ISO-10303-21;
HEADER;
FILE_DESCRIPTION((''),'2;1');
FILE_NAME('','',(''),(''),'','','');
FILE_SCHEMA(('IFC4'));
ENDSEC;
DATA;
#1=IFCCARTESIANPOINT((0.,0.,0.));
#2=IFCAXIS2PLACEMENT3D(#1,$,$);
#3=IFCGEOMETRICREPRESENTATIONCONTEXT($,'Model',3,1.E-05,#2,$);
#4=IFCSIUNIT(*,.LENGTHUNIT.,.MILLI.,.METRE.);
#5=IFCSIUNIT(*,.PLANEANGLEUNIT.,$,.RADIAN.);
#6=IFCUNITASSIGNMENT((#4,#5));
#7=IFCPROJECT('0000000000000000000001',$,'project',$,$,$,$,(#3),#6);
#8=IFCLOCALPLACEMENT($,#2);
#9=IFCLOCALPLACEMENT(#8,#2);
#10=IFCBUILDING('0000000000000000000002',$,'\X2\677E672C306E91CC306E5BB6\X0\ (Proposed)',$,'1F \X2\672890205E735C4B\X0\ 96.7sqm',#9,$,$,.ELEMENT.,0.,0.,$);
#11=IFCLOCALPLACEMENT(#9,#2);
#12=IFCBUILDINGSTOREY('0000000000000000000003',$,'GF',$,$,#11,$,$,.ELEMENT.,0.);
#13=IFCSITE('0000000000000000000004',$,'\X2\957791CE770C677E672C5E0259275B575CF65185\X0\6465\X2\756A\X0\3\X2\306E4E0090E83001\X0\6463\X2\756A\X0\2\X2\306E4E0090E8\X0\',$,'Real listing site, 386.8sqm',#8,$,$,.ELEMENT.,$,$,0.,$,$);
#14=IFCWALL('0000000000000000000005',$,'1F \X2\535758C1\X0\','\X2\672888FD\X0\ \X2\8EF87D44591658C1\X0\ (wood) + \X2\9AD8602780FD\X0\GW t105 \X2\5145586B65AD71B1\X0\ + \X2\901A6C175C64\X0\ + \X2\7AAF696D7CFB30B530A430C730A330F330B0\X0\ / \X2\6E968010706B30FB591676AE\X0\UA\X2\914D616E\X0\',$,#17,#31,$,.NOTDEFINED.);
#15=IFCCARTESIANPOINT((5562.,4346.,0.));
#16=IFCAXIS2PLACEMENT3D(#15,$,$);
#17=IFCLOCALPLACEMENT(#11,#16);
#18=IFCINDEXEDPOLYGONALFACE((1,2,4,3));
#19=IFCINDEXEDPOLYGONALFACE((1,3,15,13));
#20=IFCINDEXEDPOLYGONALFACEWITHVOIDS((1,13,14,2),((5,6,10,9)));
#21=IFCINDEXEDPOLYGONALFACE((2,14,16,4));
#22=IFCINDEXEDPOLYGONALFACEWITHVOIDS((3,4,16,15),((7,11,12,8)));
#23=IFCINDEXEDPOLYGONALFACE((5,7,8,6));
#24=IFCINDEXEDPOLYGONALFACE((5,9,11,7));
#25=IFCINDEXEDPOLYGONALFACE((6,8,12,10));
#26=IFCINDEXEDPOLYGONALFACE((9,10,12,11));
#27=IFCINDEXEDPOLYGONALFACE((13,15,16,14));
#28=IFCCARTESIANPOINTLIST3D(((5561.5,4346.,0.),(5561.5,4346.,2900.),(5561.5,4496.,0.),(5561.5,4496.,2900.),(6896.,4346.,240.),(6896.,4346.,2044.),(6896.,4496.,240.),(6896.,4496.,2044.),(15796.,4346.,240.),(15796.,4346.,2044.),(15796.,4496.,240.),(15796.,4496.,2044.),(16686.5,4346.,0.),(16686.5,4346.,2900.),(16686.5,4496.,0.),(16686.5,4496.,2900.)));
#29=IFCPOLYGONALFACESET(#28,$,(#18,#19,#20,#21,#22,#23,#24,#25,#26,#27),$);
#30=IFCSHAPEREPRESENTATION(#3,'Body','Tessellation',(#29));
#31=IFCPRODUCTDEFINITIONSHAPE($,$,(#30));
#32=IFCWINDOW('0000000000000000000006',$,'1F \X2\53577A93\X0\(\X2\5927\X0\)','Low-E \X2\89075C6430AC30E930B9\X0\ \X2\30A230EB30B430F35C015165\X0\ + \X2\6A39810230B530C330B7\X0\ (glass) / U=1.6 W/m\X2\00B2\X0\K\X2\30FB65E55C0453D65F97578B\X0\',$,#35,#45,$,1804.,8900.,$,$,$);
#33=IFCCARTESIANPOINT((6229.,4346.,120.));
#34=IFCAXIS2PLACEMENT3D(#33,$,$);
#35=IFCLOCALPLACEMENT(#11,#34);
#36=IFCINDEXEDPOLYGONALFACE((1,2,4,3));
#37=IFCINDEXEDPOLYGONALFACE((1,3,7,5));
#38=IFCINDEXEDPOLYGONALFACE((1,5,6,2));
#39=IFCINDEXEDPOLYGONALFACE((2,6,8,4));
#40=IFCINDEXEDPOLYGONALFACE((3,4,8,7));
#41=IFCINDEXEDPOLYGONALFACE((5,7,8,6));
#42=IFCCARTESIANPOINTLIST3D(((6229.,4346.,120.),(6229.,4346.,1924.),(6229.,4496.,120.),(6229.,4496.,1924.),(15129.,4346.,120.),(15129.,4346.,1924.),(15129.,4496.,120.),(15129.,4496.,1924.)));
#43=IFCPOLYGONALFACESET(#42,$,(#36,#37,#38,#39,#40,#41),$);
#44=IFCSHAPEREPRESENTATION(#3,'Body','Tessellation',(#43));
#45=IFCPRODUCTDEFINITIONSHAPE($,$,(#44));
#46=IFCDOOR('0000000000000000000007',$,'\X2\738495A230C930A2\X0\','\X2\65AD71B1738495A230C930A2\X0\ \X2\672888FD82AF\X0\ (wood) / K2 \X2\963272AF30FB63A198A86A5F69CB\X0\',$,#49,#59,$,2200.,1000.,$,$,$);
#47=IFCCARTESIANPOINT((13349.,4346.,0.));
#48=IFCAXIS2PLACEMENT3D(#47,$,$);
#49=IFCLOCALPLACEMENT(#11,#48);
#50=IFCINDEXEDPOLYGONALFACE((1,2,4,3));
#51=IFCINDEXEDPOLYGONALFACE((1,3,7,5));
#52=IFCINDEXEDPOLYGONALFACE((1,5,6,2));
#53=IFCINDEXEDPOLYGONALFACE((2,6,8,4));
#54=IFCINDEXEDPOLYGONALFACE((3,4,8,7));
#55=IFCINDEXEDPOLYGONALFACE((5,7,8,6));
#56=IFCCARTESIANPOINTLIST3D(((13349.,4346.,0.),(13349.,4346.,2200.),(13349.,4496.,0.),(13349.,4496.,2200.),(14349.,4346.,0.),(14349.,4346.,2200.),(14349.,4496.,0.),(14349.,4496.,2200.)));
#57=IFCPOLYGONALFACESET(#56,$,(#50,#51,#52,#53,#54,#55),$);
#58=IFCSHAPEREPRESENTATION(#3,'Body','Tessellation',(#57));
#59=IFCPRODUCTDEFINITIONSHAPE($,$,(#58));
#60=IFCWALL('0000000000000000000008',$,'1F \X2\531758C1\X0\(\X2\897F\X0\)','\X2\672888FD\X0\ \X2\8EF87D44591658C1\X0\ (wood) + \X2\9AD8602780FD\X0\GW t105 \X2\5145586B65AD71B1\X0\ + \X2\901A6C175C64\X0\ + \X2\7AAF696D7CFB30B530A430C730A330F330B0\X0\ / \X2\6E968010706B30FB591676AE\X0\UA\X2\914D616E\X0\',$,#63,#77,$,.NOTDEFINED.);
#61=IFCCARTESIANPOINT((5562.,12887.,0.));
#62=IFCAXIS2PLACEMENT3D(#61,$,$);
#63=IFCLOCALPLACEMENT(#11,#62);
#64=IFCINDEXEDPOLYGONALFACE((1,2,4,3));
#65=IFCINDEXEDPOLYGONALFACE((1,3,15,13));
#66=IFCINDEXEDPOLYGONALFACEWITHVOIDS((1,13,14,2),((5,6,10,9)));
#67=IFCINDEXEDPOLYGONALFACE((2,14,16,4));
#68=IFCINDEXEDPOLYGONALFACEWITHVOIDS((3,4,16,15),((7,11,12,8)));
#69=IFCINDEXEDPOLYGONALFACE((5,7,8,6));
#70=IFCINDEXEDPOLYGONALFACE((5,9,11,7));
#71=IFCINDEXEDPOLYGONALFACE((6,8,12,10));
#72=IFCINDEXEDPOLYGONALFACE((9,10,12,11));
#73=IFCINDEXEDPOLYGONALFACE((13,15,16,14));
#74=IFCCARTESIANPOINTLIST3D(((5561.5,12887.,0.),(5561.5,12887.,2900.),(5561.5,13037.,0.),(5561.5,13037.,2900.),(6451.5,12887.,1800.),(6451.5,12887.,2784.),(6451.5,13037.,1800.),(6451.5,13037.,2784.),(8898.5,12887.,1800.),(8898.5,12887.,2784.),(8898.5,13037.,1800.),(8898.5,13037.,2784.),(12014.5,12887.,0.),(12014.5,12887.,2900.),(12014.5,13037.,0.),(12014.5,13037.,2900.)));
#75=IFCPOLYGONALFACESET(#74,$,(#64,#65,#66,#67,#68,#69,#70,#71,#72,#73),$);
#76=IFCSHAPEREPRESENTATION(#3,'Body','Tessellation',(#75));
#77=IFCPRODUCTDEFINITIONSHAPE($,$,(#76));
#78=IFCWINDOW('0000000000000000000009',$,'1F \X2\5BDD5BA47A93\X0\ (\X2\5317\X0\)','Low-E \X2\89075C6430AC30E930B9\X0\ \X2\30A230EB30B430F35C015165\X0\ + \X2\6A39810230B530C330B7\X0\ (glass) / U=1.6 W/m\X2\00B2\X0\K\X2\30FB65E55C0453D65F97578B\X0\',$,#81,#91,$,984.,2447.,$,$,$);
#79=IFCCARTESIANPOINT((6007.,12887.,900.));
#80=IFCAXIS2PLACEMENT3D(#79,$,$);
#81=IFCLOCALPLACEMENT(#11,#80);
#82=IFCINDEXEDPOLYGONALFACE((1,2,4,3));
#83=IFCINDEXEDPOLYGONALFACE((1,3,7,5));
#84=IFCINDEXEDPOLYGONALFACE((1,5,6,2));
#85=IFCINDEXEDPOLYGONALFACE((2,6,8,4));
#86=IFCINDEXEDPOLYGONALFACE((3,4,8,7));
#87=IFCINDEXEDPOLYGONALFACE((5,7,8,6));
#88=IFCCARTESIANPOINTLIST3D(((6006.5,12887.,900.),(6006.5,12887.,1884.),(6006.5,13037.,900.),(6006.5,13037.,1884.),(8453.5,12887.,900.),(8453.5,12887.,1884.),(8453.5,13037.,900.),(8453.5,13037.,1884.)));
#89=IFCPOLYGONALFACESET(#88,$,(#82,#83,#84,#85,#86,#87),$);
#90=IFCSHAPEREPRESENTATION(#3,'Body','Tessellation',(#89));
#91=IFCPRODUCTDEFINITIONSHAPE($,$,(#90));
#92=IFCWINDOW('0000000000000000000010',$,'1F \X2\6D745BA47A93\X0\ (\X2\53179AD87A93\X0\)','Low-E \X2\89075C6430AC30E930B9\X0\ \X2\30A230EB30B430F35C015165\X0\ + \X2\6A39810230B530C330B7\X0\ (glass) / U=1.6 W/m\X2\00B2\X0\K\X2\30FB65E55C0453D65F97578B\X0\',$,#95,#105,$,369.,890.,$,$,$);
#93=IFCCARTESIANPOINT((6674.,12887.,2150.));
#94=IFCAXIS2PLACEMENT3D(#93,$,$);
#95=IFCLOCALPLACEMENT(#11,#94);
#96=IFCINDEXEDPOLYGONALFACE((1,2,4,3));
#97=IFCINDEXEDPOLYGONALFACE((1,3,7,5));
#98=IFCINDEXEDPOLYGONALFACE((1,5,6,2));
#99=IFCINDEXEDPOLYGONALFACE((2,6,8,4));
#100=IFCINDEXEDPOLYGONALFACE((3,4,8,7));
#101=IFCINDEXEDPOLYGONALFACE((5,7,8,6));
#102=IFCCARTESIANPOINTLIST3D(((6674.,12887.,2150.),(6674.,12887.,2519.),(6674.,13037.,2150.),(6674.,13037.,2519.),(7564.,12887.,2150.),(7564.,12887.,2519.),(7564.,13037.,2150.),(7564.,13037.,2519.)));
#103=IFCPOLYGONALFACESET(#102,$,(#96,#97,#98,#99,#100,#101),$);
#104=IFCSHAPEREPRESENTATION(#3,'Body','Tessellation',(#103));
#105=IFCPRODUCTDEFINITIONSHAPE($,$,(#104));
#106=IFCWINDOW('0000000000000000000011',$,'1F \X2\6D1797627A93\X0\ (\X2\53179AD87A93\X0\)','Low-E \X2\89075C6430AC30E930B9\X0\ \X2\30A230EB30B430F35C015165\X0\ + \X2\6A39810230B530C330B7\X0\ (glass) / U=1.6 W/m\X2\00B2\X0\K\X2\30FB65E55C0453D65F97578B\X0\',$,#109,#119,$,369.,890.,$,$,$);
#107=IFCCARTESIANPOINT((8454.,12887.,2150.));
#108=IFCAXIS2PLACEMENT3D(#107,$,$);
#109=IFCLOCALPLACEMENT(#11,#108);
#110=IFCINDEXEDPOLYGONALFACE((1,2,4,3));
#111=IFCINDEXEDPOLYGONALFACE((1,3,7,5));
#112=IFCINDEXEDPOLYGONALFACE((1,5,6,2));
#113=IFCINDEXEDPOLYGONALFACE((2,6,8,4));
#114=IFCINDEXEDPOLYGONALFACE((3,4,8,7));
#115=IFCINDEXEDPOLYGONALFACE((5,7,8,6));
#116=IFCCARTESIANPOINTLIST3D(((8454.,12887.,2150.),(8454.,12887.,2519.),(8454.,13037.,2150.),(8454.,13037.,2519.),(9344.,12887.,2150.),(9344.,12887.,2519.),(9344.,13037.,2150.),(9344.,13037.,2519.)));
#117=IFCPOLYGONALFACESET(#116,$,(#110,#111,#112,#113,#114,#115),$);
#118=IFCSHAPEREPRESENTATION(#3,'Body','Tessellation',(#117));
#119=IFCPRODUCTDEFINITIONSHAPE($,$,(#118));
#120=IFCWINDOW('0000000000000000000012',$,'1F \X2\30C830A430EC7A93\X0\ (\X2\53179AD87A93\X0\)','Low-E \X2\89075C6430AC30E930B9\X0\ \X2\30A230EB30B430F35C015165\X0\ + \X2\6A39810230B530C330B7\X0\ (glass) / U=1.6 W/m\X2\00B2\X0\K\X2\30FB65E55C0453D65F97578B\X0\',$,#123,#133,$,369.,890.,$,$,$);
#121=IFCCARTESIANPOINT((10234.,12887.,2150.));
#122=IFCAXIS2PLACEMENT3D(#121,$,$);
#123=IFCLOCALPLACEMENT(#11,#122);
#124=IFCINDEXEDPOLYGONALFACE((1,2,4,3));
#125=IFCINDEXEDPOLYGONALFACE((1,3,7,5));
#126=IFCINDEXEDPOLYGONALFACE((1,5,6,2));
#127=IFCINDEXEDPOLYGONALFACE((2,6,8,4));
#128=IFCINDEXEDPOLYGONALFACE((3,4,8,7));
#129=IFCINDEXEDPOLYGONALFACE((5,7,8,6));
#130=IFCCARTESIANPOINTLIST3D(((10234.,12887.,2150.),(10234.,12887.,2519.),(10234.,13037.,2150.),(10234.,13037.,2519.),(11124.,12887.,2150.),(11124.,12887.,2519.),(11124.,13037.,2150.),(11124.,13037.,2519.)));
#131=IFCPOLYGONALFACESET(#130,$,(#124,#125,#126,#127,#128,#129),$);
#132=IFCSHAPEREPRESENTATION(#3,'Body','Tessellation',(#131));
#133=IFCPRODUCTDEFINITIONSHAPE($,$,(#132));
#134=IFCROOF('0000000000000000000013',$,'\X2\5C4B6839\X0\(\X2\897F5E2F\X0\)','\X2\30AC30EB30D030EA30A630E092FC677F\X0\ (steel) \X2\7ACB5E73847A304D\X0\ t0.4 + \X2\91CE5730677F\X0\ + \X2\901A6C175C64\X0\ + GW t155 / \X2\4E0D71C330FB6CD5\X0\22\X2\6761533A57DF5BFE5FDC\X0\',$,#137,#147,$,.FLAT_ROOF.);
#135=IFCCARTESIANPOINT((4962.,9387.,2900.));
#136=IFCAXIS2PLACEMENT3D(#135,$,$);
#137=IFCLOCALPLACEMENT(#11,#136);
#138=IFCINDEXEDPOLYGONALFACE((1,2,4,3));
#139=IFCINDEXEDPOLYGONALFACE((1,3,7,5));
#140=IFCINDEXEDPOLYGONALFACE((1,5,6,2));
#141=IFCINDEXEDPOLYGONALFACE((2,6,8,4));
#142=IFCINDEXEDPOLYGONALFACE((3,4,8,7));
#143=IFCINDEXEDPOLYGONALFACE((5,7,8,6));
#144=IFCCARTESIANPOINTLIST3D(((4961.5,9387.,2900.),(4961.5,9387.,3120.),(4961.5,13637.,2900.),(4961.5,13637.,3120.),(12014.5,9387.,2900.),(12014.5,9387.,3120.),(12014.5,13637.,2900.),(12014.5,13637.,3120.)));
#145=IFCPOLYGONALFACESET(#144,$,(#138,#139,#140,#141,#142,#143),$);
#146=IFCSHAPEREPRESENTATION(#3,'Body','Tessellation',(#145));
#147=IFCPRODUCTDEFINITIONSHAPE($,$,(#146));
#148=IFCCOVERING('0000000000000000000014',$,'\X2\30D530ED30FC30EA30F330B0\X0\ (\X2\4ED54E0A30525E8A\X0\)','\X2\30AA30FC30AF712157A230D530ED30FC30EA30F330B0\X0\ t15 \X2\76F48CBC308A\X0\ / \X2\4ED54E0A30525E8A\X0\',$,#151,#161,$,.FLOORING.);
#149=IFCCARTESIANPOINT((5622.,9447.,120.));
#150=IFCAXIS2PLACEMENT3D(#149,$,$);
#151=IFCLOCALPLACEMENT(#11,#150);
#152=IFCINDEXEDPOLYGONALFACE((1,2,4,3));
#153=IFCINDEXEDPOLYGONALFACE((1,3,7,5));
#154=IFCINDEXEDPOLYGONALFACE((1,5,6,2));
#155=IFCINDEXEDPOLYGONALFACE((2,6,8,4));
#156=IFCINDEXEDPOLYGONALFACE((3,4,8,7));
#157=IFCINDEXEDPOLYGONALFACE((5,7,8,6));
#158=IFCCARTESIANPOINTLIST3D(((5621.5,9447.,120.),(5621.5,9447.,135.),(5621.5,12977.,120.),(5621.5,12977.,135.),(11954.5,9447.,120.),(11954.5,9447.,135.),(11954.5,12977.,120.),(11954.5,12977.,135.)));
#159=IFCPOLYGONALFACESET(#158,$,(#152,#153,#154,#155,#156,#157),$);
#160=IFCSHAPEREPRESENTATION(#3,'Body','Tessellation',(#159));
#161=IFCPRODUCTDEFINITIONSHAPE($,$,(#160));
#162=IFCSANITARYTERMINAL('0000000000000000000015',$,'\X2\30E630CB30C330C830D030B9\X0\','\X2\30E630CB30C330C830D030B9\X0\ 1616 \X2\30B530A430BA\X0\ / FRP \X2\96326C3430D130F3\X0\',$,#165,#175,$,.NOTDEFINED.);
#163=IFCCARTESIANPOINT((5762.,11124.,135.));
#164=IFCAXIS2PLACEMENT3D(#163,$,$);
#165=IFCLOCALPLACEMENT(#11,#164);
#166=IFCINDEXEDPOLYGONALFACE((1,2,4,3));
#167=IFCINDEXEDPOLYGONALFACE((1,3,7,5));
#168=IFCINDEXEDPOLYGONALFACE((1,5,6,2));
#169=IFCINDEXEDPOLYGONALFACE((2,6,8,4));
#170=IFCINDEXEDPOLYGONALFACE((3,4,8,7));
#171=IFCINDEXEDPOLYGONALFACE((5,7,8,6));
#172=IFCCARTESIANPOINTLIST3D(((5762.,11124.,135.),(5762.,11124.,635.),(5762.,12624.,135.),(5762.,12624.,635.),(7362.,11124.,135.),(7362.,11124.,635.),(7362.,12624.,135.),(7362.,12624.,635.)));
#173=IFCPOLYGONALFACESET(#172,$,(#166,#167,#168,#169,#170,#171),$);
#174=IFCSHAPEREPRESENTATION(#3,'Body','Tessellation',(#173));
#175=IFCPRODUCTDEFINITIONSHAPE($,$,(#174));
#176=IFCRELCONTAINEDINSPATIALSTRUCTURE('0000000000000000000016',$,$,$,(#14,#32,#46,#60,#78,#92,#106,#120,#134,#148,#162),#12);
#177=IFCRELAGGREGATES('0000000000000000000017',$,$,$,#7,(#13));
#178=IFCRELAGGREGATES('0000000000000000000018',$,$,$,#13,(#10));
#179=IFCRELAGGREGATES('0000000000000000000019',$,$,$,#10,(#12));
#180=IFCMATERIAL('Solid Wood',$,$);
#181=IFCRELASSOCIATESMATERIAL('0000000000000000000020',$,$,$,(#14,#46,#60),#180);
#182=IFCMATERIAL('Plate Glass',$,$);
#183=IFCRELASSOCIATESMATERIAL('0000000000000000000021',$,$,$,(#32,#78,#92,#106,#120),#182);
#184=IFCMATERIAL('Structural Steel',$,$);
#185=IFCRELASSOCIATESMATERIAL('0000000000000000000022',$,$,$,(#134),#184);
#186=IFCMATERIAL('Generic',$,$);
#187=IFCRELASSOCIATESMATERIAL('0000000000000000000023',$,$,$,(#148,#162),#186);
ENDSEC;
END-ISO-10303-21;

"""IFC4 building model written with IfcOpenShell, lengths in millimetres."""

from ifc_helpers import new_model, si_unit, frame, frame_2d, origin, place, context, project, spatial, rectangle, extrude, material, element, fill, save


model = new_model("IFC4")

# Units and contexts
model_context = context("Model", 3, precision=1e-05, world=origin())
ifc_project = project(units=[si_unit("LENGTHUNIT", "METRE", prefix="MILLI"), si_unit("PLANEANGLEUNIT", "RADIAN")], contexts=[model_context])

# Site, building, storey
site_placement = place(None, origin())
site = spatial("IfcSite", under=ifc_project, at=site_placement, Name="長野県松本市大字島内6465番3の一部、6463番2の一部", ObjectType="Real listing site, 386.8sqm", CompositionType="ELEMENT", RefElevation=0.0)
building_placement = place(site_placement, origin())
building = spatial("IfcBuilding", under=site, at=building_placement, Name="松本の里の家 (Proposed)", ObjectType="1F 木造平屋 96.7sqm", CompositionType="ELEMENT", ElevationOfRefHeight=0.0, ElevationOfTerrain=0.0)
storey_placement = place(building_placement, origin())
storey = spatial("IfcBuildingStorey", under=building, at=storey_placement, Name="GF", CompositionType="ELEMENT", Elevation=0.0)

# Shared definitions
ifc_material_1 = material(Name="Solid Wood")

# Wall, openings, window, door
wall_1_placement = place(storey_placement, frame((5562.0, 4346.0, 0.0)))
wall_1 = element("IfcWall", 1, at=wall_1_placement, inside=storey, material=ifc_material_1, Name="1F 南壁", Description="木製 軸組外壁 (wood) + 高性能GW t105 充填断熱 + 通気層 + 窯業系サイディング / 準耐火・外皮UA配慮", PredefinedType="NOTDEFINED", context=model_context, shape_type="SweptSolid", body=[
    extrude(rectangle(XDim=11125.0, YDim=150.0, at=frame_2d((5562.0, 75.0))), frame((5562.0, 4346.0, 0.0)), (0.0, 0.0, 1.0), 2900.0),
])
opening_1_placement = place(storey_placement, frame((6229.0, 4346.0, 120.0)))
opening_1 = element("IfcOpeningElement", 2, at=opening_1_placement, cuts=wall_1, PredefinedType="NOTDEFINED", context=model_context, shape_type="SweptSolid", body=[
    extrude(rectangle(XDim=8900.0, YDim=150.0, at=frame_2d((4450.0, 75.0))), frame((6229.0, 4346.0, 120.0)), (0.0, 0.0, 1.0), 1804.0),
])
opening_2_placement = place(storey_placement, frame((13349.0, 4346.0, 0.0)))
opening_2 = element("IfcOpeningElement", 3, at=opening_2_placement, cuts=wall_1, PredefinedType="NOTDEFINED", context=model_context, shape_type="SweptSolid", body=[
    extrude(rectangle(XDim=1000.0, YDim=150.0, at=frame_2d((500.0, 75.0))), frame((13349.0, 4346.0, 0.0)), (0.0, 0.0, 1.0), 2200.0),
])
ifc_material_2 = material(Name="Plate Glass")
window_1_placement = place(storey_placement, frame((6229.0, 4346.0, 120.0)))
window_1 = element("IfcWindow", 4, at=window_1_placement, inside=storey, material=ifc_material_2, Name="1F 南窓(大)", Description="Low-E 複層ガラス アルゴン封入 + 樹脂サッシ (glass) / U=1.6 W/m²K・日射取得型", OverallHeight=1804.0, OverallWidth=8900.0, context=model_context, shape_type="SweptSolid", body=[
    extrude(rectangle(XDim=8900.0, YDim=150.0, at=frame_2d((4450.0, 75.0))), frame((6229.0, 4346.0, 120.0)), (0.0, 0.0, 1.0), 1804.0),
])
fill(opening_1, window_1)
door_1_placement = place(storey_placement, frame((13349.0, 4346.0, 0.0)))
door_1 = element("IfcDoor", 5, at=door_1_placement, inside=storey, material=ifc_material_1, Name="玄関ドア", Description="断熱玄関ドア 木製芯 (wood) / K2 防犯・採風機構", OverallHeight=2200.0, OverallWidth=1000.0, context=model_context, shape_type="SweptSolid", body=[
    extrude(rectangle(XDim=1000.0, YDim=150.0, at=frame_2d((500.0, 75.0))), frame((13349.0, 4346.0, 0.0)), (0.0, 0.0, 1.0), 2200.0),
])
fill(opening_2, door_1)

# Wall, openings, windows
wall_2_placement = place(storey_placement, frame((5562.0, 12887.0, 0.0)))
wall_2 = element("IfcWall", 6, at=wall_2_placement, inside=storey, material=ifc_material_1, Name="1F 北壁(西)", Description="木製 軸組外壁 (wood) + 高性能GW t105 充填断熱 + 通気層 + 窯業系サイディング / 準耐火・外皮UA配慮", PredefinedType="NOTDEFINED", context=model_context, shape_type="SweptSolid", body=[
    extrude(rectangle(XDim=6453.0, YDim=150.0, at=frame_2d((3226.0, 75.0))), frame((5562.0, 12887.0, 0.0)), (0.0, 0.0, 1.0), 2900.0),
])
opening_3_placement = place(storey_placement, frame((6007.0, 12887.0, 900.0)))
opening_3 = element("IfcOpeningElement", 7, at=opening_3_placement, cuts=wall_2, PredefinedType="NOTDEFINED", context=model_context, shape_type="SweptSolid", body=[
    extrude(rectangle(XDim=2447.0, YDim=150.0, at=frame_2d((1223.0, 75.0))), frame((6007.0, 12887.0, 900.0)), (0.0, 0.0, 1.0), 984.0),
])
opening_4_placement = place(storey_placement, frame((6674.0, 12887.0, 2150.0)))
opening_4 = element("IfcOpeningElement", 8, at=opening_4_placement, cuts=wall_2, PredefinedType="NOTDEFINED", context=model_context, shape_type="SweptSolid", body=[
    extrude(rectangle(XDim=890.0, YDim=150.0, at=frame_2d((445.0, 75.0))), frame((6674.0, 12887.0, 2150.0)), (0.0, 0.0, 1.0), 369.0),
])
opening_5_placement = place(storey_placement, frame((8454.0, 12887.0, 2150.0)))
opening_5 = element("IfcOpeningElement", 9, at=opening_5_placement, cuts=wall_2, PredefinedType="NOTDEFINED", context=model_context, shape_type="SweptSolid", body=[
    extrude(rectangle(XDim=890.0, YDim=150.0, at=frame_2d((445.0, 75.0))), frame((8454.0, 12887.0, 2150.0)), (0.0, 0.0, 1.0), 369.0),
])
opening_6_placement = place(storey_placement, frame((10234.0, 12887.0, 2150.0)))
opening_6 = element("IfcOpeningElement", 10, at=opening_6_placement, cuts=wall_2, PredefinedType="NOTDEFINED", context=model_context, shape_type="SweptSolid", body=[
    extrude(rectangle(XDim=890.0, YDim=150.0, at=frame_2d((445.0, 75.0))), frame((10234.0, 12887.0, 2150.0)), (0.0, 0.0, 1.0), 369.0),
])
window_2_placement = place(storey_placement, frame((6007.0, 12887.0, 900.0)))
window_2 = element("IfcWindow", 11, at=window_2_placement, inside=storey, material=ifc_material_2, Name="1F 寝室窓 (北)", Description="Low-E 複層ガラス アルゴン封入 + 樹脂サッシ (glass) / U=1.6 W/m²K・日射取得型", OverallHeight=984.0, OverallWidth=2447.0, context=model_context, shape_type="SweptSolid", body=[
    extrude(rectangle(XDim=2447.0, YDim=150.0, at=frame_2d((1223.0, 75.0))), frame((6007.0, 12887.0, 900.0)), (0.0, 0.0, 1.0), 984.0),
])
fill(opening_3, window_2)
window_3_placement = place(storey_placement, frame((6674.0, 12887.0, 2150.0)))
window_3 = element("IfcWindow", 12, at=window_3_placement, inside=storey, material=ifc_material_2, Name="1F 浴室窓 (北高窓)", Description="Low-E 複層ガラス アルゴン封入 + 樹脂サッシ (glass) / U=1.6 W/m²K・日射取得型", OverallHeight=369.0, OverallWidth=890.0, context=model_context, shape_type="SweptSolid", body=[
    extrude(rectangle(XDim=890.0, YDim=150.0, at=frame_2d((445.0, 75.0))), frame((6674.0, 12887.0, 2150.0)), (0.0, 0.0, 1.0), 369.0),
])
fill(opening_4, window_3)
window_4_placement = place(storey_placement, frame((8454.0, 12887.0, 2150.0)))
window_4 = element("IfcWindow", 13, at=window_4_placement, inside=storey, material=ifc_material_2, Name="1F 洗面窓 (北高窓)", Description="Low-E 複層ガラス アルゴン封入 + 樹脂サッシ (glass) / U=1.6 W/m²K・日射取得型", OverallHeight=369.0, OverallWidth=890.0, context=model_context, shape_type="SweptSolid", body=[
    extrude(rectangle(XDim=890.0, YDim=150.0, at=frame_2d((445.0, 75.0))), frame((8454.0, 12887.0, 2150.0)), (0.0, 0.0, 1.0), 369.0),
])
fill(opening_5, window_4)
window_5_placement = place(storey_placement, frame((10234.0, 12887.0, 2150.0)))
window_5 = element("IfcWindow", 14, at=window_5_placement, inside=storey, material=ifc_material_2, Name="1F トイレ窓 (北高窓)", Description="Low-E 複層ガラス アルゴン封入 + 樹脂サッシ (glass) / U=1.6 W/m²K・日射取得型", OverallHeight=369.0, OverallWidth=890.0, context=model_context, shape_type="SweptSolid", body=[
    extrude(rectangle(XDim=890.0, YDim=150.0, at=frame_2d((445.0, 75.0))), frame((10234.0, 12887.0, 2150.0)), (0.0, 0.0, 1.0), 369.0),
])
fill(opening_6, window_5)

# Roof
ifc_material_3 = material(Name="Structural Steel")
roof_1_placement = place(storey_placement, frame((4962.0, 9387.0, 2900.0)))
element("IfcRoof", 15, at=roof_1_placement, inside=storey, material=ifc_material_3, Name="屋根(西帯)", Description="ガルバリウム鋼板 (steel) 立平葺き t0.4 + 野地板 + 通気層 + GW t155 / 不燃・法22条区域対応", PredefinedType="FLAT_ROOF", context=model_context, shape_type="SweptSolid", body=[
    extrude(rectangle(XDim=7053.0, YDim=4250.0, at=frame_2d((3526.0, 2125.0))), frame((4962.0, 9387.0, 2900.0)), (0.0, 0.0, 1.0), 220.0),
])

# Covering
ifc_material_4 = material(Name="Generic")
covering_1_placement = place(storey_placement, frame((5622.0, 9447.0, 120.0)))
element("IfcCovering", 16, at=covering_1_placement, inside=storey, material=ifc_material_4, Name="フローリング (仕上げ床)", Description="オーク無垢フローリング t15 直貼り / 仕上げ床", PredefinedType="FLOORING", context=model_context, shape_type="SweptSolid", body=[
    extrude(rectangle(XDim=6333.0, YDim=3530.0, at=frame_2d((3166.0, 1765.0))), frame((5622.0, 9447.0, 120.0)), (0.0, 0.0, 1.0), 15.0),
])

# Sanitary terminal
sanitary_terminal_placement = place(storey_placement, frame((5762.0, 11124.0, 135.0)))
element("IfcSanitaryTerminal", 17, at=sanitary_terminal_placement, inside=storey, material=ifc_material_4, Name="ユニットバス", Description="ユニットバス 1616 サイズ / FRP 防水パン", PredefinedType="NOTDEFINED", context=model_context, shape_type="SweptSolid", body=[
    extrude(rectangle(XDim=1600.0, YDim=1500.0, at=frame_2d((800.0, 750.0))), frame((5762.0, 11124.0, 135.0)), (0.0, 0.0, 1.0), 500.0),
])

save(model, "model.ifc")
